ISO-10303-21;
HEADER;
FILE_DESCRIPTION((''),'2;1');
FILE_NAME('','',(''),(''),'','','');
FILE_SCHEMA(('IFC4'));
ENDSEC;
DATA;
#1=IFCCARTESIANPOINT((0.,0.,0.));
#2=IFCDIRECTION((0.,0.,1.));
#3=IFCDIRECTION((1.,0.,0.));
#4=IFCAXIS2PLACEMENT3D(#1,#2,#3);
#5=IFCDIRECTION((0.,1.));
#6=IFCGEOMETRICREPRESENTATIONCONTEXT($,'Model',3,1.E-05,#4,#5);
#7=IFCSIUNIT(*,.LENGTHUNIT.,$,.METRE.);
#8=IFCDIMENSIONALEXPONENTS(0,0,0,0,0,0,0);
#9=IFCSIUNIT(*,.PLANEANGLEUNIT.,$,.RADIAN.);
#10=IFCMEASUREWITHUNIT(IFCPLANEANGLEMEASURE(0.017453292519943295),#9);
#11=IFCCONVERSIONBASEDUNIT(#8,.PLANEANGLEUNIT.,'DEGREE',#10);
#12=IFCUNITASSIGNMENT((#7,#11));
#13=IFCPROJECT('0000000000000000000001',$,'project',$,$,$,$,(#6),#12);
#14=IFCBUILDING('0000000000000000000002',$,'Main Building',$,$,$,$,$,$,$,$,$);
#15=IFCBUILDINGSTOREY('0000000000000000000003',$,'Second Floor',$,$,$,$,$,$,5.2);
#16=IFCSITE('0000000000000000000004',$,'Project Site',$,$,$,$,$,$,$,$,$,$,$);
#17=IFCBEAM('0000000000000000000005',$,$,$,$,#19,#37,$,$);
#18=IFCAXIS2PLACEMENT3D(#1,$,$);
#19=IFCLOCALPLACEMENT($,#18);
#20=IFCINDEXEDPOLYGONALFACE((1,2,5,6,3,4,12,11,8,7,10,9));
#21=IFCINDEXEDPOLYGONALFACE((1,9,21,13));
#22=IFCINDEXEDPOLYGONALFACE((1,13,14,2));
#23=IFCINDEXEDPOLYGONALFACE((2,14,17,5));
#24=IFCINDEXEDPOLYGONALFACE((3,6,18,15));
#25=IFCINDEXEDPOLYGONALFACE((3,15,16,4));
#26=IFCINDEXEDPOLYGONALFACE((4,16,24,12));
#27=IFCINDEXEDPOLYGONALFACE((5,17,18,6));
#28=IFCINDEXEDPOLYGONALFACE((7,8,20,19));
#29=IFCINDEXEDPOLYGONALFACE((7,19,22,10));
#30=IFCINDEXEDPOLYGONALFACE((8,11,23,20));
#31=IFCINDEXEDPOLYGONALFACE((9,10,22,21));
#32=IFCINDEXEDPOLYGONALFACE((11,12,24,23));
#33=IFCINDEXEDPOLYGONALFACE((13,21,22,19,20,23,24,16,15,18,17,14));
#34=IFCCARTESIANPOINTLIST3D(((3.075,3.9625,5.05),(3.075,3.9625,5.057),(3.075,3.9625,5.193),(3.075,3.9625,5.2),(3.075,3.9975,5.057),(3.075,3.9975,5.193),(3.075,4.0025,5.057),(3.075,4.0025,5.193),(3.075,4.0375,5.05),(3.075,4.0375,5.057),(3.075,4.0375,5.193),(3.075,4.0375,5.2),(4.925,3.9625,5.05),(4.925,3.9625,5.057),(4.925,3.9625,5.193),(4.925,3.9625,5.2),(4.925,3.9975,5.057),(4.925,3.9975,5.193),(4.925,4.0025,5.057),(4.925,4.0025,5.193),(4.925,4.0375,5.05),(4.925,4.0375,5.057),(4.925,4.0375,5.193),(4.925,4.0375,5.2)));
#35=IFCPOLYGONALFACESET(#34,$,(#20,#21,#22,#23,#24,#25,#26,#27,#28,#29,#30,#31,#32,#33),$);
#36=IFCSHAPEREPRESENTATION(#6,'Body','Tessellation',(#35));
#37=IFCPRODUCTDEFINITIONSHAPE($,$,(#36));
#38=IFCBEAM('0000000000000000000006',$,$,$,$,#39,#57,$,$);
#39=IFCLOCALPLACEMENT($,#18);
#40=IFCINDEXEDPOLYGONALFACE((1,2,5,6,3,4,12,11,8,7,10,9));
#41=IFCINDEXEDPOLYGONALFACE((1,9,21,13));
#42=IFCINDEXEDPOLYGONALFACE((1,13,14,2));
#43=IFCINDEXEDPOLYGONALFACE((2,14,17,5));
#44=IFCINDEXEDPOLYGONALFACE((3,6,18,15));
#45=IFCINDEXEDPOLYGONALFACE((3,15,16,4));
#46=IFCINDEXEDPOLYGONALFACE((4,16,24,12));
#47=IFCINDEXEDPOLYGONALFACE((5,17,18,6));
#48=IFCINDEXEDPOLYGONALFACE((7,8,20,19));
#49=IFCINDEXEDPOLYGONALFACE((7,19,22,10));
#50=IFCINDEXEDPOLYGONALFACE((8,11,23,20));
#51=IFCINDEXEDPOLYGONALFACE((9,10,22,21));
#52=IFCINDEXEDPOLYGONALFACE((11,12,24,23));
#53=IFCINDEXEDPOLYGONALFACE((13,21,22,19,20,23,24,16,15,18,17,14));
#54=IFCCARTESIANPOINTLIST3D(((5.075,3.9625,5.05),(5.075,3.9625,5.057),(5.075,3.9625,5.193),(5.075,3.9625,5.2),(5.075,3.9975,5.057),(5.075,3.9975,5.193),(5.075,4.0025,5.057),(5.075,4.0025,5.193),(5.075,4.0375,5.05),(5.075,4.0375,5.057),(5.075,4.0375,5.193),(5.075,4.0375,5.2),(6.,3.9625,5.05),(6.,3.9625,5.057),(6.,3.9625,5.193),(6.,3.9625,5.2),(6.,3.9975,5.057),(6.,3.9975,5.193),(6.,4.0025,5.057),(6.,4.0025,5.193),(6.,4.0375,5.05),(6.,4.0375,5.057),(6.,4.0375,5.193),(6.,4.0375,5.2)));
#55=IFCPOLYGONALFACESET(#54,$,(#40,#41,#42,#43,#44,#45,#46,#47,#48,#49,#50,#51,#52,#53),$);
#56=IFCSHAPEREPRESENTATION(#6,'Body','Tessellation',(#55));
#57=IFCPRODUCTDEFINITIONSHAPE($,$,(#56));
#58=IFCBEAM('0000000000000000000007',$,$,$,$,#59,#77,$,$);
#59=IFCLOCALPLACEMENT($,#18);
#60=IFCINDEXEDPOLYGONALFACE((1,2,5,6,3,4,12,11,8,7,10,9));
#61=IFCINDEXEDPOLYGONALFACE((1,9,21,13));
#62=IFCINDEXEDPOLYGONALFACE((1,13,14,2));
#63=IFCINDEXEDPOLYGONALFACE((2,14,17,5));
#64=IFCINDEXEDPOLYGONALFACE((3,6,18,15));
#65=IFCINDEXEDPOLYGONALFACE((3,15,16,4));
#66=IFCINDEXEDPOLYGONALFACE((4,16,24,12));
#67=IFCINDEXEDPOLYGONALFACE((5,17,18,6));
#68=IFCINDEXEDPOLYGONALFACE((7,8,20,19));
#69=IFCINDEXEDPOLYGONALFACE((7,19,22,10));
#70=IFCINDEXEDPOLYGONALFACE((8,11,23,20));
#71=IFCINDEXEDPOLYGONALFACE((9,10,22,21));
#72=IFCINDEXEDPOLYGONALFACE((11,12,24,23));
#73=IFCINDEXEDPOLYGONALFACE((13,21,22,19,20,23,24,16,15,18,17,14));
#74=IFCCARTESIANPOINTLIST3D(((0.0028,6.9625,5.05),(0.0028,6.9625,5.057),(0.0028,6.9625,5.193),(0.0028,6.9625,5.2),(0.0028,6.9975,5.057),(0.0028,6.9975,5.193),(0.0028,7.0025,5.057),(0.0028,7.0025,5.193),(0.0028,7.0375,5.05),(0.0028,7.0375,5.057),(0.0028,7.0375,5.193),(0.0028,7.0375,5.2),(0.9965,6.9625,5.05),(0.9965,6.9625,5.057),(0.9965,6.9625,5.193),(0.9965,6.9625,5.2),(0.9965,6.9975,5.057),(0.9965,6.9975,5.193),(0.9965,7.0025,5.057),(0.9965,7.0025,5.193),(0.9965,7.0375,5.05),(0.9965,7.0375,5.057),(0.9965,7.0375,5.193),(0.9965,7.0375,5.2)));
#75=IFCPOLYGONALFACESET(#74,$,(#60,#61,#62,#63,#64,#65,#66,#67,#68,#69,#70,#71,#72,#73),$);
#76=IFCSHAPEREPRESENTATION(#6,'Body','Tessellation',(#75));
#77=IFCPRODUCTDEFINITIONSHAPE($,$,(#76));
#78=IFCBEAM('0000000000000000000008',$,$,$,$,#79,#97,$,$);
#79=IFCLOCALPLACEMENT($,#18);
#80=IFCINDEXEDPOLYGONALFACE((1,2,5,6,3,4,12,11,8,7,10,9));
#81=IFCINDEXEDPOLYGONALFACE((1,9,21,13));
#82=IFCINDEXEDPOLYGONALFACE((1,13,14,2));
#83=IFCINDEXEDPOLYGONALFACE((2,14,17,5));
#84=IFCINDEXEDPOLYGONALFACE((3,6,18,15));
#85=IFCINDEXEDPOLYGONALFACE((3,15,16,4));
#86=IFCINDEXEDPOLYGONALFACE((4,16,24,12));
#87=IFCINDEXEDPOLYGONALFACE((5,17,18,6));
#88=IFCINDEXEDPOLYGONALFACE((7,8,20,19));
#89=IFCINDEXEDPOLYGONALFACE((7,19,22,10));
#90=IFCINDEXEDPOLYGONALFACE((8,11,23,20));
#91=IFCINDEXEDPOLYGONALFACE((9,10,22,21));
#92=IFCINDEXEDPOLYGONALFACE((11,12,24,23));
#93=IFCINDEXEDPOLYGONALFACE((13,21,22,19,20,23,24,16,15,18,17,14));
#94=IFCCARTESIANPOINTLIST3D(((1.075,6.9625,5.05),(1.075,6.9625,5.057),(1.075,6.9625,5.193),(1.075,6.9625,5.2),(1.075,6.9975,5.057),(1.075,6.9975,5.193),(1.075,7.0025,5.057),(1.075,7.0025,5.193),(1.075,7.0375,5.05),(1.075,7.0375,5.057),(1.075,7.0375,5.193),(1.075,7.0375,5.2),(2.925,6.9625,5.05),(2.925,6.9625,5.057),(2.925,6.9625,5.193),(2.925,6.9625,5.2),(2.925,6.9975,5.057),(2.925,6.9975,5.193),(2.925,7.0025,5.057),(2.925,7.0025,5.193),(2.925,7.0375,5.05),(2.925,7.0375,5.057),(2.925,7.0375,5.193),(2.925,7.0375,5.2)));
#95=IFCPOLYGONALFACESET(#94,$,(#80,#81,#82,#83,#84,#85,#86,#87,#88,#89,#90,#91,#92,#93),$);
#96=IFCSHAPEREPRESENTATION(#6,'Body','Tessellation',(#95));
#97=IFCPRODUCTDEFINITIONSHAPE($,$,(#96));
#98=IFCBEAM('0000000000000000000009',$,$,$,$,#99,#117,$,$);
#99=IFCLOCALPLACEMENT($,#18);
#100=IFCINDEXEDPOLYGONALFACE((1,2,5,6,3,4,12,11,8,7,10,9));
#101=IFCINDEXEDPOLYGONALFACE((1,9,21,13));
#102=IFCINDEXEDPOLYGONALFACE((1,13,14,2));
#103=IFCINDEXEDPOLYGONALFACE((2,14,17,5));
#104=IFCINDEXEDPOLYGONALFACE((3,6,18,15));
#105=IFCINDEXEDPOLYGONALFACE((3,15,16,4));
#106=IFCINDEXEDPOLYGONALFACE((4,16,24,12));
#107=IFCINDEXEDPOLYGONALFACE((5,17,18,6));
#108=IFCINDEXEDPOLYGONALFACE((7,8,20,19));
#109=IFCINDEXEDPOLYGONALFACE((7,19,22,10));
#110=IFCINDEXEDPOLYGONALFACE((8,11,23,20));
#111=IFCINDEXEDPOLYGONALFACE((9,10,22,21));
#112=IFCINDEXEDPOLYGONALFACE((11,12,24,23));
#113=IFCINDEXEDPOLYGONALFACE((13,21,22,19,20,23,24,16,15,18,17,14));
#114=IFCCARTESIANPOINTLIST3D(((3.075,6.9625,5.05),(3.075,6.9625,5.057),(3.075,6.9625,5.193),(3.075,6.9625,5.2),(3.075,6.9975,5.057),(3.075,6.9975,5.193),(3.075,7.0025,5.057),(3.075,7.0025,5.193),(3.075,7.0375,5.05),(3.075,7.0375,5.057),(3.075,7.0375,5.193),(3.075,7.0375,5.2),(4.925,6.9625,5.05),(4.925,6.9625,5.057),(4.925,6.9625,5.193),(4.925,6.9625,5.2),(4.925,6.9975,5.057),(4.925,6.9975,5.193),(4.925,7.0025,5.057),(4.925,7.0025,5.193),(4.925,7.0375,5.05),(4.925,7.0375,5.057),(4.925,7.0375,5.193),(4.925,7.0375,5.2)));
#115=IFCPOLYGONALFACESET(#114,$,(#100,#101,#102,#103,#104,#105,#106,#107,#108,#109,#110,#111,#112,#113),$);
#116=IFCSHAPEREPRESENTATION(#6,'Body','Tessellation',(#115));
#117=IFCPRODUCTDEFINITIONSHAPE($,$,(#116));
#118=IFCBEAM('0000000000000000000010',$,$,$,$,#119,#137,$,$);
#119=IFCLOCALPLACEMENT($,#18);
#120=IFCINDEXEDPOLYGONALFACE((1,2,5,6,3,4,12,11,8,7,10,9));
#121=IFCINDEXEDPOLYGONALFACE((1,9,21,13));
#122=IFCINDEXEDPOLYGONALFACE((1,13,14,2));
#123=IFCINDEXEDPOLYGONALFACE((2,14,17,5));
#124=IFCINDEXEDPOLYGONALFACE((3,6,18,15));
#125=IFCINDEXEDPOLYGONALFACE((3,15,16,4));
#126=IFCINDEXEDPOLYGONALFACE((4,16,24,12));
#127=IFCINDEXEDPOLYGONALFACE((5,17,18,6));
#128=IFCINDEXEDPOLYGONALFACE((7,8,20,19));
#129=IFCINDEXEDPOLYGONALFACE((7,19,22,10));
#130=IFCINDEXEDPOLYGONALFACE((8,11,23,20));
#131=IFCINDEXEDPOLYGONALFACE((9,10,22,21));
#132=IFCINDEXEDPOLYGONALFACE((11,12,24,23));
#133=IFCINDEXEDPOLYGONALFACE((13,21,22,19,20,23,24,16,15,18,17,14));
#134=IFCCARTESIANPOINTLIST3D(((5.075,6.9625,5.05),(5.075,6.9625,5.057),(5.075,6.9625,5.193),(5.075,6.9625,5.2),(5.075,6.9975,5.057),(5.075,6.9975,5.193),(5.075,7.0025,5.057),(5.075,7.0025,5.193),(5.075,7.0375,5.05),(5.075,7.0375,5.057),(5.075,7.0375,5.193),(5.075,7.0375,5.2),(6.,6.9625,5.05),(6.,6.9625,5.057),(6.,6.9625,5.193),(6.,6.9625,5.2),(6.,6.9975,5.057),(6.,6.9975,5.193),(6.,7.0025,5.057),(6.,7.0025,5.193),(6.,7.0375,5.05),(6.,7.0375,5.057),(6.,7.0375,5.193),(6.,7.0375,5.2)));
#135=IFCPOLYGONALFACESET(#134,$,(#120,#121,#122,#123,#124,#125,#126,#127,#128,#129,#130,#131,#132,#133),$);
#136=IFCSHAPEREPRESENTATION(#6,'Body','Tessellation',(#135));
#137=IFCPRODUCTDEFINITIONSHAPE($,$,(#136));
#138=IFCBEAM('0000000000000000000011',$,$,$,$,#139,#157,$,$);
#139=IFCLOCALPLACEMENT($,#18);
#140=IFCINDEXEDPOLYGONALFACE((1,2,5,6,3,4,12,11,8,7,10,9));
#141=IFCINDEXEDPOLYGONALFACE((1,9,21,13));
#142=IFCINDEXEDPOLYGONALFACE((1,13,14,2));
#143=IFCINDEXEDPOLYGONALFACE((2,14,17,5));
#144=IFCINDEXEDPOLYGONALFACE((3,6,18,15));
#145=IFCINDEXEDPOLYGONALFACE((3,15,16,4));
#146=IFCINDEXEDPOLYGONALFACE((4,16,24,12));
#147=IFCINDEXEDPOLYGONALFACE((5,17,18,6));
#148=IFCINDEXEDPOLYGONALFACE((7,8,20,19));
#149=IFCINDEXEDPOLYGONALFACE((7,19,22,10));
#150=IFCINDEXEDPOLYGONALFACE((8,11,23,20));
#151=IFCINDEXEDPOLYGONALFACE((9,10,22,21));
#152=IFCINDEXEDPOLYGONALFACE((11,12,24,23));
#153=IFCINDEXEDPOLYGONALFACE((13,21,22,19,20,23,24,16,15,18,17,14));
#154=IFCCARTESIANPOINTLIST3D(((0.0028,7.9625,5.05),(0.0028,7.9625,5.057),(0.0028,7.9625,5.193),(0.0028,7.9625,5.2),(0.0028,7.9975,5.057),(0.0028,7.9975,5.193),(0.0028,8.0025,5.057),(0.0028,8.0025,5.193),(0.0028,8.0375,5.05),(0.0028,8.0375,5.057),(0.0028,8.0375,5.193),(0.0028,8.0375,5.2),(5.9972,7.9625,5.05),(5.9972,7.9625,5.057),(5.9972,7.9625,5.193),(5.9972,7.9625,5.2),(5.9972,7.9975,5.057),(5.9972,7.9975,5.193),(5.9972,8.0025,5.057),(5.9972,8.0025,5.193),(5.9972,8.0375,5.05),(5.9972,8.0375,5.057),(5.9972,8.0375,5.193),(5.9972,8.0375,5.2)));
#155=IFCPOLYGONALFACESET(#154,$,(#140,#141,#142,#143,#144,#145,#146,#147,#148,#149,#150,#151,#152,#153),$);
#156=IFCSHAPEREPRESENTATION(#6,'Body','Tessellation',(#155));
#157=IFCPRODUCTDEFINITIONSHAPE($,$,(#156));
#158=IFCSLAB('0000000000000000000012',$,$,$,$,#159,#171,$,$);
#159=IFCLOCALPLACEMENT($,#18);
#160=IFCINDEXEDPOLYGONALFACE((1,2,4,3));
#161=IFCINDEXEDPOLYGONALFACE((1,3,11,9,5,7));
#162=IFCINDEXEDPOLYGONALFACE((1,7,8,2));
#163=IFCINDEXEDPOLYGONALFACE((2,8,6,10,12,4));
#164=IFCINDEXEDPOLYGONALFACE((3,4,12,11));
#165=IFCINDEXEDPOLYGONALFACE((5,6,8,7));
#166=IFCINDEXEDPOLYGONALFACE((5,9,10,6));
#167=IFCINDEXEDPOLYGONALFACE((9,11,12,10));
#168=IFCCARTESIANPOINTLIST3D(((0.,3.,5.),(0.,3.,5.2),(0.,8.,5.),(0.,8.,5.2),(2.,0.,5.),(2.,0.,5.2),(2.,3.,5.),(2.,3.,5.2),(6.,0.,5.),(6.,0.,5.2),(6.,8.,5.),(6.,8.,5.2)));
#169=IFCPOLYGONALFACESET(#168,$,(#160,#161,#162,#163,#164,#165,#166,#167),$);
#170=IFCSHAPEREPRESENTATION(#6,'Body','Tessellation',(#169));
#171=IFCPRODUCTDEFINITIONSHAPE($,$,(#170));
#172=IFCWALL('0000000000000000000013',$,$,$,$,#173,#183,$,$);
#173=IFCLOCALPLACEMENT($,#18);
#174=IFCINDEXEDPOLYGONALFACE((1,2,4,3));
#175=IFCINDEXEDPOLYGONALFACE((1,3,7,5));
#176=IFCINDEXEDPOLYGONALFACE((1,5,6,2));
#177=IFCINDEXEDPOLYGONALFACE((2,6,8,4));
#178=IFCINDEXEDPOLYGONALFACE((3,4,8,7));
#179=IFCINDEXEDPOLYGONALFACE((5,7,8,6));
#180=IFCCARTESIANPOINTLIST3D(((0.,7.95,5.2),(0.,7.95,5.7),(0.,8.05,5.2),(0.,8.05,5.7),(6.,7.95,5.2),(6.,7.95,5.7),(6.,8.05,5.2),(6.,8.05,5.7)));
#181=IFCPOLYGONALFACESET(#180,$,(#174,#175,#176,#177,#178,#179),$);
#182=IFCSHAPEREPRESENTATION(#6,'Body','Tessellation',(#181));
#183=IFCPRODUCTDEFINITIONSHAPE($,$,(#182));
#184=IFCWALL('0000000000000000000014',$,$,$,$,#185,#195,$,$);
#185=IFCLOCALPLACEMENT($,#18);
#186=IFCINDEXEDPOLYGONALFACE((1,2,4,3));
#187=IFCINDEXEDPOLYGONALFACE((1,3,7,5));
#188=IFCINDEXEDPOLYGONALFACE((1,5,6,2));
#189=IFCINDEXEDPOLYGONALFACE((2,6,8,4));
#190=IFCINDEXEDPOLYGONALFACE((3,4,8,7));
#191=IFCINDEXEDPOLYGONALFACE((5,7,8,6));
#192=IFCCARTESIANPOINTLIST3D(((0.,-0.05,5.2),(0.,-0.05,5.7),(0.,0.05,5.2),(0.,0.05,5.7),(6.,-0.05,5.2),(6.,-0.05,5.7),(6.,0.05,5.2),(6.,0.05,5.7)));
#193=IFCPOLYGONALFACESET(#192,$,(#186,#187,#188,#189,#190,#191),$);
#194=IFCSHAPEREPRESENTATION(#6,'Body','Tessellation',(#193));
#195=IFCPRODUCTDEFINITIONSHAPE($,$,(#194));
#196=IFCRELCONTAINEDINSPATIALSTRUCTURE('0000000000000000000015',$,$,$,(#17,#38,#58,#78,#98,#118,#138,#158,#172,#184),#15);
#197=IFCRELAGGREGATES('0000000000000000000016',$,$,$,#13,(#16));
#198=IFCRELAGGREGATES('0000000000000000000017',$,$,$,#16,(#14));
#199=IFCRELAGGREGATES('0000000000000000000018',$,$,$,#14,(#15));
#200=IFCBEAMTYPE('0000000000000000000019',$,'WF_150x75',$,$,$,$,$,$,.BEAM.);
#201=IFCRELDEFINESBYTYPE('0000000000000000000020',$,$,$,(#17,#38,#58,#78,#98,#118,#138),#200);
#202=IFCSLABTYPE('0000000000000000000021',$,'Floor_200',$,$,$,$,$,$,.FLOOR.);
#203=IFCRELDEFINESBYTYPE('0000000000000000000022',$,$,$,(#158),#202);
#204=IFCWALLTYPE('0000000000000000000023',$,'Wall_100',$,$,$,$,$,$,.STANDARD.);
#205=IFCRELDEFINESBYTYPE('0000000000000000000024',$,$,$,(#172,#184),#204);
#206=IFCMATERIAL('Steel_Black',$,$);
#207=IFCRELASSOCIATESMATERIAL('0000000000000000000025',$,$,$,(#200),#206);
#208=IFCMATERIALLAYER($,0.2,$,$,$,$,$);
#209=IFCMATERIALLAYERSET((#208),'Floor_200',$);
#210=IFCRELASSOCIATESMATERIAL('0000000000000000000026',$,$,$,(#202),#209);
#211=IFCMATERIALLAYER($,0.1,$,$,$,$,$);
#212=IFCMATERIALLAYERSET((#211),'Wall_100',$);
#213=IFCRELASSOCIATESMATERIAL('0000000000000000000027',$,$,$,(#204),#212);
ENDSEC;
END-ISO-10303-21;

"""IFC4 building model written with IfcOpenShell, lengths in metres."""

from ifc_helpers import new_model, entity, si_unit, converted_unit, direction, frame, frame_2d, origin, origin_with_axes, origin_2d, place, context, project, spatial, polyline, rectangle, i_section, outline, extrude, material, layer, layer_set, material_profile, profile_set, type_object, element, save


model = new_model("IFC4")

# Units and contexts
model_context = context("Model", 3, precision=1e-05, world=origin_with_axes(), true_north=direction((0.0, 1.0)))
ifc_project = project(units=[si_unit("LENGTHUNIT", "METRE"), converted_unit("PLANEANGLEUNIT", "DEGREE", entity("IfcPlaneAngleMeasure", 0.017453292519943295), si_unit("PLANEANGLEUNIT", "RADIAN"), dimensions=[0, 0, 0, 0, 0, 0, 0])], contexts=[model_context])

# Site, building, storey
site = spatial("IfcSite", under=ifc_project, Name="Project Site")
building = spatial("IfcBuilding", under=site, Name="Main Building")
storey = spatial("IfcBuildingStorey", under=building, Name="Second Floor", Elevation=5.2)

# Beams
ifc_material = material(Name="Steel_Black")
ifc_material_profile_1 = material_profile(ifc_material, i_section(OverallWidth=0.075, OverallDepth=0.15, WebThickness=0.005, FlangeThickness=0.007, at=origin_2d()), Name="WF_150x75")
ifc_profile_set_1 = profile_set([ifc_material_profile_1], Name="WF_150x75")
beam_type_1 = type_object("IfcBeamType", Name="WF_150x75", PredefinedType="BEAM", material=ifc_profile_set_1)
for number, where, z_axis, x_axis in (
    (1, (3.075, 4.0, 5.05), (0.0, 0.0, 1.0), (1.0, 0.0, 0.0)),
):
    element("IfcBeam", number, at=place(None, frame(where, z_axis=z_axis, x_axis=x_axis)), inside=storey, type_object=beam_type_1, context=model_context, shape_type="SweptSolid", body=[
        extrude(i_section(OverallWidth=0.075, OverallDepth=0.15, WebThickness=0.005, FlangeThickness=0.007, at=frame_2d((0.0, 0.075))), frame((0.0, 0.0, 0.0), z_axis=(1.0, 0.0, 0.0), x_axis=(0.0, 1.0, 0.0)), (0.0, 0.0, 1.0), 1.85),
    ])
beam_1_placement = place(None, frame((5.075, 4.0, 5.05), z_axis=(0.0, 0.0, 1.0), x_axis=(1.0, 0.0, 0.0)))
element("IfcBeam", 2, at=beam_1_placement, inside=storey, type_object=beam_type_1, context=model_context, shape_type="SweptSolid", body=[
    extrude(i_section(OverallWidth=0.075, OverallDepth=0.15, WebThickness=0.005, FlangeThickness=0.007, at=frame_2d((0.0, 0.075))), frame((0.0, 0.0, 0.0), z_axis=(1.0, 0.0, 0.0), x_axis=(0.0, 1.0, 0.0)), (0.0, 0.0, 1.0), 0.925),
])
beam_2_placement = place(None, frame((0.0027, 7.0, 5.05), z_axis=(0.0, 0.0, 1.0), x_axis=(1.0, 0.0, 0.0)))
element("IfcBeam", 3, at=beam_2_placement, inside=storey, type_object=beam_type_1, context=model_context, shape_type="SweptSolid", body=[
    extrude(i_section(OverallWidth=0.075, OverallDepth=0.15, WebThickness=0.005, FlangeThickness=0.007, at=frame_2d((0.0, 0.075))), frame((0.0, 0.0, 0.0), z_axis=(1.0, 0.0, 0.0), x_axis=(0.0, 1.0, 0.0)), (0.0, 0.0, 1.0), 0.9938),
])
for number, where, z_axis, x_axis in (
    (4, (1.075, 7.0, 5.05), (0.0, 0.0, 1.0), (1.0, 0.0, 0.0)),
    (5, (3.075, 7.0, 5.05), (0.0, 0.0, 1.0), (1.0, 0.0, 0.0)),
):
    element("IfcBeam", number, at=place(None, frame(where, z_axis=z_axis, x_axis=x_axis)), inside=storey, type_object=beam_type_1, context=model_context, shape_type="SweptSolid", body=[
        extrude(i_section(OverallWidth=0.075, OverallDepth=0.15, WebThickness=0.005, FlangeThickness=0.007, at=frame_2d((0.0, 0.075))), frame((0.0, 0.0, 0.0), z_axis=(1.0, 0.0, 0.0), x_axis=(0.0, 1.0, 0.0)), (0.0, 0.0, 1.0), 1.85),
    ])
beam_3_placement = place(None, frame((5.075, 7.0, 5.05), z_axis=(0.0, 0.0, 1.0), x_axis=(1.0, 0.0, 0.0)))
element("IfcBeam", 6, at=beam_3_placement, inside=storey, type_object=beam_type_1, context=model_context, shape_type="SweptSolid", body=[
    extrude(i_section(OverallWidth=0.075, OverallDepth=0.15, WebThickness=0.005, FlangeThickness=0.007, at=frame_2d((0.0, 0.075))), frame((0.0, 0.0, 0.0), z_axis=(1.0, 0.0, 0.0), x_axis=(0.0, 1.0, 0.0)), (0.0, 0.0, 1.0), 0.925),
])
beam_4_placement = place(None, frame((0.0027, 8.0, 5.05), z_axis=(0.0, 0.0, 1.0), x_axis=(1.0, 0.0, 0.0)))
element("IfcBeam", 7, at=beam_4_placement, inside=storey, type_object=beam_type_1, context=model_context, shape_type="SweptSolid", body=[
    extrude(i_section(OverallWidth=0.075, OverallDepth=0.15, WebThickness=0.005, FlangeThickness=0.007, at=frame_2d((0.0, 0.075))), frame((0.0, 0.0, 0.0), z_axis=(1.0, 0.0, 0.0), x_axis=(0.0, 1.0, 0.0)), (0.0, 0.0, 1.0), 5.9945),
])

# Slab
ifc_layer_1 = layer(None, 0.2)
ifc_layer_set_1 = layer_set([ifc_layer_1], Name="Floor_200")
slab_type = type_object("IfcSlabType", Name="Floor_200", PredefinedType="FLOOR", material=ifc_layer_set_1)
slab_placement = place(None, frame((0.0, 0.0, 5.0), z_axis=(0.0, 0.0, 1.0), x_axis=(1.0, 0.0, 0.0)))
element("IfcSlab", 8, at=slab_placement, inside=storey, type_object=slab_type, context=model_context, shape_type="SweptSolid", body=[
    extrude(outline(polyline([(0.0, 3.0), (2.0, 3.0), (2.0, 0.0), (6.0, 0.0), (6.0, 8.0), (0.0, 8.0), (0.0, 3.0)])), origin(), (0.0, 0.0, 1.0), 0.2),
])

# Walls
ifc_layer_2 = layer(None, 0.1)
ifc_layer_set_2 = layer_set([ifc_layer_2], Name="Wall_100")
wall_type = type_object("IfcWallType", Name="Wall_100", PredefinedType="STANDARD", material=ifc_layer_set_2)
for number, where, z_axis, x_axis in (
    (9, (0.0, 8.0, 5.2), (0.0, 0.0, 1.0), (1.0, 0.0, 0.0)),
    (10, (0.0, 0.0, 5.2), (0.0, 0.0, 1.0), (1.0, 0.0, 0.0)),
):
    element("IfcWall", number, at=place(None, frame(where, z_axis=z_axis, x_axis=x_axis)), inside=storey, type_object=wall_type, context=model_context, shape_type="SweptSolid", body=[
        extrude(rectangle(XDim=6.0, YDim=0.1, at=frame_2d((3.0, 0.0))), origin(), (0.0, 0.0, 1.0), 0.5),
    ])

save(model, "model.ifc")
